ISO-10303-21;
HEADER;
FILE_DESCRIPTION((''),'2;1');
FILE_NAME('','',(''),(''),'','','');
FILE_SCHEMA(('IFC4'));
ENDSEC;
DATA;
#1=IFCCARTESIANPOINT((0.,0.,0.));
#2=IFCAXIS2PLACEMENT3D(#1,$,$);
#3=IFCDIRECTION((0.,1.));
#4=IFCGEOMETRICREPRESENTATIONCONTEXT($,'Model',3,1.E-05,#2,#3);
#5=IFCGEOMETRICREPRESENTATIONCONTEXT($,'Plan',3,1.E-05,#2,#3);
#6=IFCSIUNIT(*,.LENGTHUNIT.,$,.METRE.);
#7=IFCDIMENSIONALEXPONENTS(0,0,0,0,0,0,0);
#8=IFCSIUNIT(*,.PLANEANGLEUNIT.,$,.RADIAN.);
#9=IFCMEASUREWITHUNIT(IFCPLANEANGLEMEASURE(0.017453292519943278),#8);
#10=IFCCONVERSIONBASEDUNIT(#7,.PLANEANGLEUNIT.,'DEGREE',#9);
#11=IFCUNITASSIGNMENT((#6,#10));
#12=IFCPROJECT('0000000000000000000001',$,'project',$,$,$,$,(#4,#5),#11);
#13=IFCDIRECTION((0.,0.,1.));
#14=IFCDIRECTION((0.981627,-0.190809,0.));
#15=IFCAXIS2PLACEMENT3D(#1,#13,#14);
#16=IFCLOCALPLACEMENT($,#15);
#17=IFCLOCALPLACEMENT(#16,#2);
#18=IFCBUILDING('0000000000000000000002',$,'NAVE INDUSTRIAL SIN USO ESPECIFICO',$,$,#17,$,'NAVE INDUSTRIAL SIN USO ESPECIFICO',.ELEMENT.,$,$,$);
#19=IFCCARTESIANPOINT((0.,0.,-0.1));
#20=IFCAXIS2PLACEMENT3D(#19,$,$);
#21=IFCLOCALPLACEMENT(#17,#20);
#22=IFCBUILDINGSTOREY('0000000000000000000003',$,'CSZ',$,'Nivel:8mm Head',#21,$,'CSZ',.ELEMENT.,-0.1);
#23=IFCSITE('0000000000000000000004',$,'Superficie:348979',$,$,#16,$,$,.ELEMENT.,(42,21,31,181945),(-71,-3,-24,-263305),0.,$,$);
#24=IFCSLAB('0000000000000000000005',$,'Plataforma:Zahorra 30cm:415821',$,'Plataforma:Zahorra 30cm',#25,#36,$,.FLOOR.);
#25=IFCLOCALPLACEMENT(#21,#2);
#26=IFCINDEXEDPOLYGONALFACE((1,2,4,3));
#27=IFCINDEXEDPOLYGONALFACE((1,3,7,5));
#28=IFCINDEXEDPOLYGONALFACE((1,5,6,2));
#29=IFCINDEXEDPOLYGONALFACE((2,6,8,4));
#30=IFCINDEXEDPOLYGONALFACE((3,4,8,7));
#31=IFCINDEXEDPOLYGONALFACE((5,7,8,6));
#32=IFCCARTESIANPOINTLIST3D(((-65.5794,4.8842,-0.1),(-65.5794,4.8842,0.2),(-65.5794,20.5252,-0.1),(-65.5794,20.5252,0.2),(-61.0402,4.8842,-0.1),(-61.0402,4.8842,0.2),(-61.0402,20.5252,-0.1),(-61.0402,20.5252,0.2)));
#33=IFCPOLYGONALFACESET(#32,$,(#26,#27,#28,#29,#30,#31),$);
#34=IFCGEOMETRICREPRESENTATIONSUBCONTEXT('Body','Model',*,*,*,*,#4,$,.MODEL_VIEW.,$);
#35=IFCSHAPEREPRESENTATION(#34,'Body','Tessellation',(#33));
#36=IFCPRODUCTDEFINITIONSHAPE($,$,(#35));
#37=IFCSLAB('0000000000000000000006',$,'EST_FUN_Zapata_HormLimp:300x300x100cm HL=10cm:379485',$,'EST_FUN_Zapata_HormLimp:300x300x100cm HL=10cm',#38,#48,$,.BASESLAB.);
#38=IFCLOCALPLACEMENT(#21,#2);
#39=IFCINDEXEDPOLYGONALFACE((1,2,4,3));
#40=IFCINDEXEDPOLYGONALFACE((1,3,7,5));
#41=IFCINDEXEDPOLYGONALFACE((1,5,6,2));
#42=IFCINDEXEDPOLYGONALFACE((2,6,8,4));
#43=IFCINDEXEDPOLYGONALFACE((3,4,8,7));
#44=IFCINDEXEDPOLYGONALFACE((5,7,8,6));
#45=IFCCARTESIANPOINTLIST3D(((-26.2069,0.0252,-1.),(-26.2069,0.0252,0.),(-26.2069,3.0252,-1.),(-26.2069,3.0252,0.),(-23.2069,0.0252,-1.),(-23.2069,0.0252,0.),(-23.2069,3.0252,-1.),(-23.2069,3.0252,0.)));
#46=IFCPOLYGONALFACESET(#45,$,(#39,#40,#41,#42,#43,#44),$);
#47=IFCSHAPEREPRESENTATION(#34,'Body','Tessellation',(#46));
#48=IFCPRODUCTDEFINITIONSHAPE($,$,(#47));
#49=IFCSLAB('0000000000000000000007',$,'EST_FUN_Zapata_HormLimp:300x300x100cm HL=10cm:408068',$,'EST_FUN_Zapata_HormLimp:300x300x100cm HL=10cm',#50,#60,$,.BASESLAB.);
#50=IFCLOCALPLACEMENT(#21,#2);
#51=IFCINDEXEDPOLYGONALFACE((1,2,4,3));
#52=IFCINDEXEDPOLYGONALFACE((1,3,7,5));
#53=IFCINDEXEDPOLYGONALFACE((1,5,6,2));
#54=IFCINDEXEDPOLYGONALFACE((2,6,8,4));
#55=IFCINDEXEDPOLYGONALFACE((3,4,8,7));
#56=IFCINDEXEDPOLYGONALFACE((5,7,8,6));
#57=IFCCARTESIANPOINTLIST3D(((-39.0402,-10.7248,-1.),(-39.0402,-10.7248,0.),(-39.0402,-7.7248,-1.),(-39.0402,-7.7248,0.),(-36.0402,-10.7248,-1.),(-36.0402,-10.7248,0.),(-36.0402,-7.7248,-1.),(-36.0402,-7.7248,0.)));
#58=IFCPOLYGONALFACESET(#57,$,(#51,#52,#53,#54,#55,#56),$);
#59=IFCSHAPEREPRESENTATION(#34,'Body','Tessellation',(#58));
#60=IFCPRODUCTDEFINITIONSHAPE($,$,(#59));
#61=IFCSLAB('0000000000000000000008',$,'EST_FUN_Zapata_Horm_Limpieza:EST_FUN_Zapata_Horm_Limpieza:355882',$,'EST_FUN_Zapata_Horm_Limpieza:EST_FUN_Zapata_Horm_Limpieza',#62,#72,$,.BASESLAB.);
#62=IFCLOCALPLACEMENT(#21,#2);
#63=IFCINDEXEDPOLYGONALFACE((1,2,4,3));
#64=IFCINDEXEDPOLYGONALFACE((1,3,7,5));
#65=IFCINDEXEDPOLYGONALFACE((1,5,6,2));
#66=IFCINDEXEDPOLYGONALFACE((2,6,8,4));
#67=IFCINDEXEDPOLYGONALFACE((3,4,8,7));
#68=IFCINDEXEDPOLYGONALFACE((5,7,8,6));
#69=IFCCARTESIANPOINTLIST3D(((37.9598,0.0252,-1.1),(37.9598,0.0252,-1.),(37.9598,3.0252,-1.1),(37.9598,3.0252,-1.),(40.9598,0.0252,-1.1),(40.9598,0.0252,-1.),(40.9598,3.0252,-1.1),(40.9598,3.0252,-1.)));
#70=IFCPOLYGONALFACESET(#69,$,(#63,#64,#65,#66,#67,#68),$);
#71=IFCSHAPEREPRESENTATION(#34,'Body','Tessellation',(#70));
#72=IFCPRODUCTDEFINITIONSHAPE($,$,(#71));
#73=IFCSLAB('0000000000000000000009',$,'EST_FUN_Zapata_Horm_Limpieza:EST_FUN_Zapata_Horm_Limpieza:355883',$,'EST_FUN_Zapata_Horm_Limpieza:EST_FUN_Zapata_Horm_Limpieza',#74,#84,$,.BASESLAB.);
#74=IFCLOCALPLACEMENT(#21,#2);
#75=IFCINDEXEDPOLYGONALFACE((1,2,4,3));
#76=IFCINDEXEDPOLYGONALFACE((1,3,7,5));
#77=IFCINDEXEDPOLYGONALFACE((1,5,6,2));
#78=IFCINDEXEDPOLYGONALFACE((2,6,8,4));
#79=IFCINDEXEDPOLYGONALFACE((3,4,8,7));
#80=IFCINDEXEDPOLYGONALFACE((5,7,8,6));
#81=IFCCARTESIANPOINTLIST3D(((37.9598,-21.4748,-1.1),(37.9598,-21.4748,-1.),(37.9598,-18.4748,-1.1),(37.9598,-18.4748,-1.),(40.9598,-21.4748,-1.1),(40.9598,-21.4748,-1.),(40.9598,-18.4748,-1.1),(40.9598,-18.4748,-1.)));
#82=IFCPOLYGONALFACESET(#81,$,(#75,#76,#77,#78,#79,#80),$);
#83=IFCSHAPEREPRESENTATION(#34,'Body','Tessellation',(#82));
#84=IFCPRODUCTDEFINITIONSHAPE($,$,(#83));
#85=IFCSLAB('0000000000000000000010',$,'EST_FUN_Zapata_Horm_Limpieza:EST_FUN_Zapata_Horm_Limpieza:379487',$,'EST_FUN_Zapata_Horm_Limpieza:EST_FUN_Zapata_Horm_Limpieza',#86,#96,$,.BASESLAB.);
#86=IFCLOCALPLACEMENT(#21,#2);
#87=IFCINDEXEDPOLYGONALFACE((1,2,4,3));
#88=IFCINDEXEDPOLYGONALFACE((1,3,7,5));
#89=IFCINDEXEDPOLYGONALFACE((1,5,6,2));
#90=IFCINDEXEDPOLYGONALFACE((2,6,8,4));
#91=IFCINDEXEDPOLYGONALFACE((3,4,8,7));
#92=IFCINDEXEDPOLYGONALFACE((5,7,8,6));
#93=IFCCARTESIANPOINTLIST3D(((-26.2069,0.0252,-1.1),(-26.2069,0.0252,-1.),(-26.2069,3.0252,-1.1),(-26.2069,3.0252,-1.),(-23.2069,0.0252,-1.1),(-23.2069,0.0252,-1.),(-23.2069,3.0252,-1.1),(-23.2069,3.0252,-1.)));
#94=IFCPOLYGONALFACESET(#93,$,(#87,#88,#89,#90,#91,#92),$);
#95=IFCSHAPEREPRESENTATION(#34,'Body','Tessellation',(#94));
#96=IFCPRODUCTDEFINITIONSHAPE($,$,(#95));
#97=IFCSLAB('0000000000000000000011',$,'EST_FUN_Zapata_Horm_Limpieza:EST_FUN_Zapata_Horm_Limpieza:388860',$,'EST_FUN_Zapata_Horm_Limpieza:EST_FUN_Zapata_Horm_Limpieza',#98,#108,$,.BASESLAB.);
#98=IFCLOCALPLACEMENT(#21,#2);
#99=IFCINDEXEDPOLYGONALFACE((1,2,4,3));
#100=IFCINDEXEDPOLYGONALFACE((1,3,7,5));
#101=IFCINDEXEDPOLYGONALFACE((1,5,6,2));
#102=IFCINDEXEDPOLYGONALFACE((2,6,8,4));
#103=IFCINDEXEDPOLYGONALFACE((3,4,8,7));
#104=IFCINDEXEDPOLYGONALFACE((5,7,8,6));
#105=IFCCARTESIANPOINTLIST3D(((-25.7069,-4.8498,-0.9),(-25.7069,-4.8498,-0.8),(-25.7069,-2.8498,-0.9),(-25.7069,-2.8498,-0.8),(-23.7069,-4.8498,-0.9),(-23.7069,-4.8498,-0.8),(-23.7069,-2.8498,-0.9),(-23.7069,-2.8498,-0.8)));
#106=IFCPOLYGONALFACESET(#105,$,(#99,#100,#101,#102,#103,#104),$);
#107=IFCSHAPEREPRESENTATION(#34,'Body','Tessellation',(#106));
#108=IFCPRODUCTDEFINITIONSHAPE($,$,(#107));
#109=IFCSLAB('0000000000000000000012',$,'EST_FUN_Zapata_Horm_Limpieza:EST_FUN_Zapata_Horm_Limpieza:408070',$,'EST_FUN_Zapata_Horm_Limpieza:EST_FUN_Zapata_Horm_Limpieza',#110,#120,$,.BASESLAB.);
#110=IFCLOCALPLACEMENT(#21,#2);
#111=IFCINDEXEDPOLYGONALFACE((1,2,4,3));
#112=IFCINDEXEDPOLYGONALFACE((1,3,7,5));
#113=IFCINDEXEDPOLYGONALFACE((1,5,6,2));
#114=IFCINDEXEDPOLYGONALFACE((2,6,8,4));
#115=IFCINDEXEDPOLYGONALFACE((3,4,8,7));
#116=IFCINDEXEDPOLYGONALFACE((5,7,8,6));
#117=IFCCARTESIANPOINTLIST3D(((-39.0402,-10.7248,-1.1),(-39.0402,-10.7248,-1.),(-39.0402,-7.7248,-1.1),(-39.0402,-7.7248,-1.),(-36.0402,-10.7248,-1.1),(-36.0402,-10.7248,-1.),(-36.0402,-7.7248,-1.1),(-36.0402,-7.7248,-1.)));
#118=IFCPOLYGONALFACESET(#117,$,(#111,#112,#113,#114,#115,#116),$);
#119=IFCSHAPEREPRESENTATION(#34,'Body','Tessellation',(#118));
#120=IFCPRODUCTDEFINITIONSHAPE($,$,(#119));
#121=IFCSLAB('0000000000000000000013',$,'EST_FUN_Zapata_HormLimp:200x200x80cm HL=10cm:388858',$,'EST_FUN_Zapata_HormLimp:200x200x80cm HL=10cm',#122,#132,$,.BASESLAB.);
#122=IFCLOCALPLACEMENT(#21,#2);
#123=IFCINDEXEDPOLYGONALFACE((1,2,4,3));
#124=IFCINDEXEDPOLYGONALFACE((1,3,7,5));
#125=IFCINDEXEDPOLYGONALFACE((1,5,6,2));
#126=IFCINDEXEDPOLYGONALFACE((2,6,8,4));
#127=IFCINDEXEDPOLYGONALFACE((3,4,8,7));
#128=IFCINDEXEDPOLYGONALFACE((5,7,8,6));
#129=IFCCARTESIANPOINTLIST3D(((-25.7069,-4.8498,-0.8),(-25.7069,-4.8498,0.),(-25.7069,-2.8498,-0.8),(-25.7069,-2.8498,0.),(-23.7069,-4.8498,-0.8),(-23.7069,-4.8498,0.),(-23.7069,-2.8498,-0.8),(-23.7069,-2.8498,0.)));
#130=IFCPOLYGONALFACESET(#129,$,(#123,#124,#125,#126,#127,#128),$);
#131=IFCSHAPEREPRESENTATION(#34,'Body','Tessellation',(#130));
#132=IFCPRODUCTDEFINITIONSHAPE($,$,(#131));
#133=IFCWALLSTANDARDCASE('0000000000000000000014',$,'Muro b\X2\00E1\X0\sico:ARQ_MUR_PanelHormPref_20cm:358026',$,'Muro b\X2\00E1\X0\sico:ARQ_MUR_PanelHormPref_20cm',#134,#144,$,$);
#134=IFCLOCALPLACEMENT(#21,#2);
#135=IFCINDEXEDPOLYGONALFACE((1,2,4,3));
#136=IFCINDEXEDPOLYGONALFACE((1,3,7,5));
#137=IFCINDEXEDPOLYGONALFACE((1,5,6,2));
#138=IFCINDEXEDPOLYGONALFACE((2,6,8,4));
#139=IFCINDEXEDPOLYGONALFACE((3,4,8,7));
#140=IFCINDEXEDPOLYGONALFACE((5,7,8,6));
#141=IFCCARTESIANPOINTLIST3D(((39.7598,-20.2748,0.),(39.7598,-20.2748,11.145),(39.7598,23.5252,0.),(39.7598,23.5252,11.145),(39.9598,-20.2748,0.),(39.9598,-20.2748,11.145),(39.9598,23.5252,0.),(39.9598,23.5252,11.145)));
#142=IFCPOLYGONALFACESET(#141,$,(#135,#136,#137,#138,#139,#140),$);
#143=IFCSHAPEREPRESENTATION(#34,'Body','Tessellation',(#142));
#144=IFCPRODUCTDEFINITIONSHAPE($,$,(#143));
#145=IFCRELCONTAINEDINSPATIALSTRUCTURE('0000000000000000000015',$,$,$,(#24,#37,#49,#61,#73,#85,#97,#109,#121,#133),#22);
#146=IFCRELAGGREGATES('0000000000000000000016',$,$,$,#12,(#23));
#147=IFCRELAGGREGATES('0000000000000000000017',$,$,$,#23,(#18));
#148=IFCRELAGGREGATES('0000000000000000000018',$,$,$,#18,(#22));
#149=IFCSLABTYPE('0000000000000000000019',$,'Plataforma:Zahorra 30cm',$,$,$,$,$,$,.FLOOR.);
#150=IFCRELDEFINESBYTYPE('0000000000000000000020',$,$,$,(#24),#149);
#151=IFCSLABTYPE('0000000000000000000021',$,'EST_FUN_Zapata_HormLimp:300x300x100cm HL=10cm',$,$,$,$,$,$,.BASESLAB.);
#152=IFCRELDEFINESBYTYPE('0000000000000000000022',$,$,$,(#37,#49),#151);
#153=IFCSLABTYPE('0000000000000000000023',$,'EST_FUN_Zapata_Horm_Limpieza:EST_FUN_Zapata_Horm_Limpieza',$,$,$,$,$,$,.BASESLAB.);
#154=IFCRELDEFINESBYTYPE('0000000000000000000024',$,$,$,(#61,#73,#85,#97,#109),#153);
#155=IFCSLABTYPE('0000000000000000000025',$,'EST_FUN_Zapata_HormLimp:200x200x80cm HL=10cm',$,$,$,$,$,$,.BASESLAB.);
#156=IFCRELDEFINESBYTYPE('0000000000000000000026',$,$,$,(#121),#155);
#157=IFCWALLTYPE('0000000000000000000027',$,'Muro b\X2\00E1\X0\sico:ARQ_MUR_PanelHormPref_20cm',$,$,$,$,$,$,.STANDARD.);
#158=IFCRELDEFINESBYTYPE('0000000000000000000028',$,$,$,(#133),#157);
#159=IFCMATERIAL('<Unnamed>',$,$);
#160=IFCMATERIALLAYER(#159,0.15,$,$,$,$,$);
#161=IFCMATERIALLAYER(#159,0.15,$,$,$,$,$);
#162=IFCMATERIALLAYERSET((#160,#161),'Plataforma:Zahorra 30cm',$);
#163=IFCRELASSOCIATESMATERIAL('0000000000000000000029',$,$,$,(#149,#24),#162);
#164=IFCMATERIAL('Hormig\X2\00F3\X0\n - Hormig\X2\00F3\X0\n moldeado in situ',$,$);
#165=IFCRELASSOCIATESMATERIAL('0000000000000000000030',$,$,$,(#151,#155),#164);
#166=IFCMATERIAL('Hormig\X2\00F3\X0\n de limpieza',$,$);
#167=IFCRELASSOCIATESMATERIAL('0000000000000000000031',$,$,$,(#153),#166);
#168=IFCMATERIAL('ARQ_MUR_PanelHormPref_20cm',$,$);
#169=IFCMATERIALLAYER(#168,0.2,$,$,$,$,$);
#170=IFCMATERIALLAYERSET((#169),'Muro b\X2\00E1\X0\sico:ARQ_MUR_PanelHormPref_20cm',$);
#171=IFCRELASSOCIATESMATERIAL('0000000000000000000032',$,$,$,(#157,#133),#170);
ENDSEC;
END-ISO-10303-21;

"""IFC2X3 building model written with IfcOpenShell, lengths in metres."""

from ifc_helpers import new_model, entity, si_unit, converted_unit, direction, frame, frame_2d, origin, origin_2d_with_axis, place, context, subcontext, project, spatial, rectangle, extrude, material, layer, layer_set, layer_usage, type_object, element, save


model = new_model("IFC2X3")

# Units and contexts
model_context = context("Model", 3, precision=1e-05, world=origin(), true_north=direction((0.0, 1.0)))
plan_context = context("Plan", 3, precision=1e-05, world=origin(), true_north=direction((0.0, 1.0)))
body_context = subcontext(model_context, "Body", "Model", "MODEL_VIEW")
ifc_project = project(units=[si_unit("LENGTHUNIT", "METRE"), converted_unit("PLANEANGLEUNIT", "DEGREE", entity("IfcPlaneAngleMeasure", 0.017453292519943278), si_unit("PLANEANGLEUNIT", "RADIAN"), dimensions=[0, 0, 0, 0, 0, 0, 0])], contexts=[model_context, plan_context])

# Site, building, storey
site_placement = place(None, frame((0.0, 0.0, 0.0), z_axis=(0.0, 0.0, 1.0), x_axis=(0.981627, -0.190809, 0.0)))
site = spatial("IfcSite", under=ifc_project, at=site_placement, Name="Superficie:348979", CompositionType="ELEMENT", RefLatitude=(42, 21, 31, 181945), RefLongitude=(-71, -3, -24, -263305), RefElevation=0.0)
building_placement = place(site_placement, origin())
building = spatial("IfcBuilding", under=site, at=building_placement, Name="NAVE INDUSTRIAL SIN USO ESPECIFICO", LongName="NAVE INDUSTRIAL SIN USO ESPECIFICO", CompositionType="ELEMENT")
storey_placement = place(building_placement, frame((0.0, 0.0, -0.1)))
storey = spatial("IfcBuildingStorey", under=building, at=storey_placement, Name="CSZ", ObjectType="Nivel:8mm Head", LongName="CSZ", CompositionType="ELEMENT", Elevation=-0.1)

# Shared definitions
ifc_material_1 = material(Name="<Unnamed>")

# Slabs
ifc_layer_1 = layer(ifc_material_1, 0.15)
ifc_layer_2 = layer(ifc_material_1, 0.15)
ifc_layer_set_1 = layer_set([ifc_layer_1, ifc_layer_2], Name="Plataforma:Zahorra 30cm")
ifc_layer_usage_1 = layer_usage(ifc_layer_set_1, "AXIS3", "NEGATIVE", 0.0)
slab_type_1 = type_object("IfcSlabType", Name="Plataforma:Zahorra 30cm", PredefinedType="FLOOR", material=ifc_layer_set_1)
slab_1_placement = place(storey_placement, origin())
element("IfcSlab", 1, at=slab_1_placement, inside=storey, type_object=slab_type_1, material=ifc_layer_usage_1, Name="Plataforma:Zahorra 30cm:415821", ObjectType="Plataforma:Zahorra 30cm", PredefinedType="FLOOR", context=body_context, shape_type="SweptSolid", body=[
    extrude(rectangle(XDim=15.641, YDim=4.5392, at=frame_2d((0.0, 0.0), x_axis=(1.0, 0.0))), frame((-63.3098, 12.7047, -0.1), z_axis=(0.0, 0.0, 1.0), x_axis=(0.0, 1.0, 0.0)), (0.0, 0.0, 1.0), 0.3),
])
ifc_material_2 = material(Name="Hormigón - Hormigón moldeado in situ")
slab_type_2 = type_object("IfcSlabType", Name="EST_FUN_Zapata_HormLimp:300x300x100cm HL=10cm", PredefinedType="BASESLAB", material=ifc_material_2)
slab_2_placement = place(storey_placement, origin())
element("IfcSlab", 2, at=slab_2_placement, inside=storey, type_object=slab_type_2, Name="EST_FUN_Zapata_HormLimp:300x300x100cm HL=10cm:379485", ObjectType="EST_FUN_Zapata_HormLimp:300x300x100cm HL=10cm", PredefinedType="BASESLAB", context=body_context, shape_type="SweptSolid", body=[
    extrude(rectangle(XDim=3.0, YDim=3.0, at=frame_2d((0.0, 0.0), x_axis=(1.0, 0.0))), frame((-24.7069, 1.5252, -1.0)), (0.0, 0.0, 1.0), 1.0),
])
slab_3_placement = place(storey_placement, origin())
element("IfcSlab", 3, at=slab_3_placement, inside=storey, type_object=slab_type_2, Name="EST_FUN_Zapata_HormLimp:300x300x100cm HL=10cm:408068", ObjectType="EST_FUN_Zapata_HormLimp:300x300x100cm HL=10cm", PredefinedType="BASESLAB", context=body_context, shape_type="SweptSolid", body=[
    extrude(rectangle(XDim=3.0, YDim=3.0, at=frame_2d((0.0, 0.0), x_axis=(1.0, 0.0))), frame((-37.5402, -9.2248, -1.0)), (0.0, 0.0, 1.0), 1.0),
])
ifc_material_3 = material(Name="Hormigón de limpieza")
slab_type_3 = type_object("IfcSlabType", Name="EST_FUN_Zapata_Horm_Limpieza:EST_FUN_Zapata_Horm_Limpieza", PredefinedType="BASESLAB", material=ifc_material_3)
slab_4_placement = place(storey_placement, frame((0.0, 0.0, -1.0)))
element("IfcSlab", 4, at=slab_4_placement, inside=storey, type_object=slab_type_3, Name="EST_FUN_Zapata_Horm_Limpieza:EST_FUN_Zapata_Horm_Limpieza:355882", ObjectType="EST_FUN_Zapata_Horm_Limpieza:EST_FUN_Zapata_Horm_Limpieza", PredefinedType="BASESLAB", context=body_context, shape_type="SweptSolid", body=[
    extrude(rectangle(XDim=3.0, YDim=3.0, at=frame_2d((0.0, 0.0), x_axis=(1.0, 0.0))), frame((39.4598, 1.5252, -0.1)), (0.0, 0.0, 1.0), 0.1),
])
slab_5_placement = place(storey_placement, frame((0.0, 0.0, -1.0)))
element("IfcSlab", 5, at=slab_5_placement, inside=storey, type_object=slab_type_3, Name="EST_FUN_Zapata_Horm_Limpieza:EST_FUN_Zapata_Horm_Limpieza:355883", ObjectType="EST_FUN_Zapata_Horm_Limpieza:EST_FUN_Zapata_Horm_Limpieza", PredefinedType="BASESLAB", context=body_context, shape_type="SweptSolid", body=[
    extrude(rectangle(XDim=3.0, YDim=3.0, at=frame_2d((0.0, 0.0), x_axis=(1.0, 0.0))), frame((39.4598, -19.9748, -0.1)), (0.0, 0.0, 1.0), 0.1),
])
slab_6_placement = place(storey_placement, frame((0.0, 0.0, -1.0)))
element("IfcSlab", 6, at=slab_6_placement, inside=storey, type_object=slab_type_3, Name="EST_FUN_Zapata_Horm_Limpieza:EST_FUN_Zapata_Horm_Limpieza:379487", ObjectType="EST_FUN_Zapata_Horm_Limpieza:EST_FUN_Zapata_Horm_Limpieza", PredefinedType="BASESLAB", context=body_context, shape_type="SweptSolid", body=[
    extrude(rectangle(XDim=3.0, YDim=3.0, at=frame_2d((0.0, 0.0), x_axis=(1.0, 0.0))), frame((-24.7069, 1.5252, -0.1)), (0.0, 0.0, 1.0), 0.1),
])
slab_7_placement = place(storey_placement, frame((0.0, 0.0, -0.8)))
element("IfcSlab", 7, at=slab_7_placement, inside=storey, type_object=slab_type_3, Name="EST_FUN_Zapata_Horm_Limpieza:EST_FUN_Zapata_Horm_Limpieza:388860", ObjectType="EST_FUN_Zapata_Horm_Limpieza:EST_FUN_Zapata_Horm_Limpieza", PredefinedType="BASESLAB", context=body_context, shape_type="SweptSolid", body=[
    extrude(rectangle(XDim=2.0, YDim=2.0, at=frame_2d((0.0, 0.0), x_axis=(1.0, 0.0))), frame((-24.7069, -3.8498, -0.1)), (0.0, 0.0, 1.0), 0.1),
])
slab_8_placement = place(storey_placement, frame((0.0, 0.0, -1.0)))
element("IfcSlab", 8, at=slab_8_placement, inside=storey, type_object=slab_type_3, Name="EST_FUN_Zapata_Horm_Limpieza:EST_FUN_Zapata_Horm_Limpieza:408070", ObjectType="EST_FUN_Zapata_Horm_Limpieza:EST_FUN_Zapata_Horm_Limpieza", PredefinedType="BASESLAB", context=body_context, shape_type="SweptSolid", body=[
    extrude(rectangle(XDim=3.0, YDim=3.0, at=origin_2d_with_axis()), frame((-37.5402, -9.2248, -0.1)), (0.0, 0.0, 1.0), 0.1),
])
slab_type_4 = type_object("IfcSlabType", Name="EST_FUN_Zapata_HormLimp:200x200x80cm HL=10cm", PredefinedType="BASESLAB", material=ifc_material_2)
slab_9_placement = place(storey_placement, origin())
element("IfcSlab", 9, at=slab_9_placement, inside=storey, type_object=slab_type_4, Name="EST_FUN_Zapata_HormLimp:200x200x80cm HL=10cm:388858", ObjectType="EST_FUN_Zapata_HormLimp:200x200x80cm HL=10cm", PredefinedType="BASESLAB", context=body_context, shape_type="SweptSolid", body=[
    extrude(rectangle(XDim=2.0, YDim=2.0, at=frame_2d((0.0, 0.0), x_axis=(1.0, 0.0))), frame((-24.7069, -3.8498, -0.8)), (0.0, 0.0, 1.0), 0.8),
])

# Wall
ifc_material_4 = material(Name="ARQ_MUR_PanelHormPref_20cm")
ifc_layer_3 = layer(ifc_material_4, 0.2)
ifc_layer_set_2 = layer_set([ifc_layer_3], Name="Muro básico:ARQ_MUR_PanelHormPref_20cm")
ifc_layer_usage_2 = layer_usage(ifc_layer_set_2, "AXIS2", "NEGATIVE", 0.1)
wall_type = type_object("IfcWallType", Name="Muro básico:ARQ_MUR_PanelHormPref_20cm", PredefinedType="STANDARD", material=ifc_layer_set_2)
wall_placement = place(storey_placement, frame((39.8598, 23.5252, 0.0), z_axis=(0.0, 0.0, 1.0), x_axis=(0.0, -1.0, 0.0)))
element("IfcWallStandardCase", 10, at=wall_placement, inside=storey, type_object=wall_type, material=ifc_layer_usage_2, Name="Muro básico:ARQ_MUR_PanelHormPref_20cm:358026", ObjectType="Muro básico:ARQ_MUR_PanelHormPref_20cm", context=body_context, shape_type="SweptSolid", body=[
    extrude(rectangle(XDim=43.8, YDim=0.2, at=frame_2d((21.9, 0.0), x_axis=(-1.0, 0.0))), origin(), (0.0, 0.0, 1.0), 11.145),
])

save(model, "model.ifc")
